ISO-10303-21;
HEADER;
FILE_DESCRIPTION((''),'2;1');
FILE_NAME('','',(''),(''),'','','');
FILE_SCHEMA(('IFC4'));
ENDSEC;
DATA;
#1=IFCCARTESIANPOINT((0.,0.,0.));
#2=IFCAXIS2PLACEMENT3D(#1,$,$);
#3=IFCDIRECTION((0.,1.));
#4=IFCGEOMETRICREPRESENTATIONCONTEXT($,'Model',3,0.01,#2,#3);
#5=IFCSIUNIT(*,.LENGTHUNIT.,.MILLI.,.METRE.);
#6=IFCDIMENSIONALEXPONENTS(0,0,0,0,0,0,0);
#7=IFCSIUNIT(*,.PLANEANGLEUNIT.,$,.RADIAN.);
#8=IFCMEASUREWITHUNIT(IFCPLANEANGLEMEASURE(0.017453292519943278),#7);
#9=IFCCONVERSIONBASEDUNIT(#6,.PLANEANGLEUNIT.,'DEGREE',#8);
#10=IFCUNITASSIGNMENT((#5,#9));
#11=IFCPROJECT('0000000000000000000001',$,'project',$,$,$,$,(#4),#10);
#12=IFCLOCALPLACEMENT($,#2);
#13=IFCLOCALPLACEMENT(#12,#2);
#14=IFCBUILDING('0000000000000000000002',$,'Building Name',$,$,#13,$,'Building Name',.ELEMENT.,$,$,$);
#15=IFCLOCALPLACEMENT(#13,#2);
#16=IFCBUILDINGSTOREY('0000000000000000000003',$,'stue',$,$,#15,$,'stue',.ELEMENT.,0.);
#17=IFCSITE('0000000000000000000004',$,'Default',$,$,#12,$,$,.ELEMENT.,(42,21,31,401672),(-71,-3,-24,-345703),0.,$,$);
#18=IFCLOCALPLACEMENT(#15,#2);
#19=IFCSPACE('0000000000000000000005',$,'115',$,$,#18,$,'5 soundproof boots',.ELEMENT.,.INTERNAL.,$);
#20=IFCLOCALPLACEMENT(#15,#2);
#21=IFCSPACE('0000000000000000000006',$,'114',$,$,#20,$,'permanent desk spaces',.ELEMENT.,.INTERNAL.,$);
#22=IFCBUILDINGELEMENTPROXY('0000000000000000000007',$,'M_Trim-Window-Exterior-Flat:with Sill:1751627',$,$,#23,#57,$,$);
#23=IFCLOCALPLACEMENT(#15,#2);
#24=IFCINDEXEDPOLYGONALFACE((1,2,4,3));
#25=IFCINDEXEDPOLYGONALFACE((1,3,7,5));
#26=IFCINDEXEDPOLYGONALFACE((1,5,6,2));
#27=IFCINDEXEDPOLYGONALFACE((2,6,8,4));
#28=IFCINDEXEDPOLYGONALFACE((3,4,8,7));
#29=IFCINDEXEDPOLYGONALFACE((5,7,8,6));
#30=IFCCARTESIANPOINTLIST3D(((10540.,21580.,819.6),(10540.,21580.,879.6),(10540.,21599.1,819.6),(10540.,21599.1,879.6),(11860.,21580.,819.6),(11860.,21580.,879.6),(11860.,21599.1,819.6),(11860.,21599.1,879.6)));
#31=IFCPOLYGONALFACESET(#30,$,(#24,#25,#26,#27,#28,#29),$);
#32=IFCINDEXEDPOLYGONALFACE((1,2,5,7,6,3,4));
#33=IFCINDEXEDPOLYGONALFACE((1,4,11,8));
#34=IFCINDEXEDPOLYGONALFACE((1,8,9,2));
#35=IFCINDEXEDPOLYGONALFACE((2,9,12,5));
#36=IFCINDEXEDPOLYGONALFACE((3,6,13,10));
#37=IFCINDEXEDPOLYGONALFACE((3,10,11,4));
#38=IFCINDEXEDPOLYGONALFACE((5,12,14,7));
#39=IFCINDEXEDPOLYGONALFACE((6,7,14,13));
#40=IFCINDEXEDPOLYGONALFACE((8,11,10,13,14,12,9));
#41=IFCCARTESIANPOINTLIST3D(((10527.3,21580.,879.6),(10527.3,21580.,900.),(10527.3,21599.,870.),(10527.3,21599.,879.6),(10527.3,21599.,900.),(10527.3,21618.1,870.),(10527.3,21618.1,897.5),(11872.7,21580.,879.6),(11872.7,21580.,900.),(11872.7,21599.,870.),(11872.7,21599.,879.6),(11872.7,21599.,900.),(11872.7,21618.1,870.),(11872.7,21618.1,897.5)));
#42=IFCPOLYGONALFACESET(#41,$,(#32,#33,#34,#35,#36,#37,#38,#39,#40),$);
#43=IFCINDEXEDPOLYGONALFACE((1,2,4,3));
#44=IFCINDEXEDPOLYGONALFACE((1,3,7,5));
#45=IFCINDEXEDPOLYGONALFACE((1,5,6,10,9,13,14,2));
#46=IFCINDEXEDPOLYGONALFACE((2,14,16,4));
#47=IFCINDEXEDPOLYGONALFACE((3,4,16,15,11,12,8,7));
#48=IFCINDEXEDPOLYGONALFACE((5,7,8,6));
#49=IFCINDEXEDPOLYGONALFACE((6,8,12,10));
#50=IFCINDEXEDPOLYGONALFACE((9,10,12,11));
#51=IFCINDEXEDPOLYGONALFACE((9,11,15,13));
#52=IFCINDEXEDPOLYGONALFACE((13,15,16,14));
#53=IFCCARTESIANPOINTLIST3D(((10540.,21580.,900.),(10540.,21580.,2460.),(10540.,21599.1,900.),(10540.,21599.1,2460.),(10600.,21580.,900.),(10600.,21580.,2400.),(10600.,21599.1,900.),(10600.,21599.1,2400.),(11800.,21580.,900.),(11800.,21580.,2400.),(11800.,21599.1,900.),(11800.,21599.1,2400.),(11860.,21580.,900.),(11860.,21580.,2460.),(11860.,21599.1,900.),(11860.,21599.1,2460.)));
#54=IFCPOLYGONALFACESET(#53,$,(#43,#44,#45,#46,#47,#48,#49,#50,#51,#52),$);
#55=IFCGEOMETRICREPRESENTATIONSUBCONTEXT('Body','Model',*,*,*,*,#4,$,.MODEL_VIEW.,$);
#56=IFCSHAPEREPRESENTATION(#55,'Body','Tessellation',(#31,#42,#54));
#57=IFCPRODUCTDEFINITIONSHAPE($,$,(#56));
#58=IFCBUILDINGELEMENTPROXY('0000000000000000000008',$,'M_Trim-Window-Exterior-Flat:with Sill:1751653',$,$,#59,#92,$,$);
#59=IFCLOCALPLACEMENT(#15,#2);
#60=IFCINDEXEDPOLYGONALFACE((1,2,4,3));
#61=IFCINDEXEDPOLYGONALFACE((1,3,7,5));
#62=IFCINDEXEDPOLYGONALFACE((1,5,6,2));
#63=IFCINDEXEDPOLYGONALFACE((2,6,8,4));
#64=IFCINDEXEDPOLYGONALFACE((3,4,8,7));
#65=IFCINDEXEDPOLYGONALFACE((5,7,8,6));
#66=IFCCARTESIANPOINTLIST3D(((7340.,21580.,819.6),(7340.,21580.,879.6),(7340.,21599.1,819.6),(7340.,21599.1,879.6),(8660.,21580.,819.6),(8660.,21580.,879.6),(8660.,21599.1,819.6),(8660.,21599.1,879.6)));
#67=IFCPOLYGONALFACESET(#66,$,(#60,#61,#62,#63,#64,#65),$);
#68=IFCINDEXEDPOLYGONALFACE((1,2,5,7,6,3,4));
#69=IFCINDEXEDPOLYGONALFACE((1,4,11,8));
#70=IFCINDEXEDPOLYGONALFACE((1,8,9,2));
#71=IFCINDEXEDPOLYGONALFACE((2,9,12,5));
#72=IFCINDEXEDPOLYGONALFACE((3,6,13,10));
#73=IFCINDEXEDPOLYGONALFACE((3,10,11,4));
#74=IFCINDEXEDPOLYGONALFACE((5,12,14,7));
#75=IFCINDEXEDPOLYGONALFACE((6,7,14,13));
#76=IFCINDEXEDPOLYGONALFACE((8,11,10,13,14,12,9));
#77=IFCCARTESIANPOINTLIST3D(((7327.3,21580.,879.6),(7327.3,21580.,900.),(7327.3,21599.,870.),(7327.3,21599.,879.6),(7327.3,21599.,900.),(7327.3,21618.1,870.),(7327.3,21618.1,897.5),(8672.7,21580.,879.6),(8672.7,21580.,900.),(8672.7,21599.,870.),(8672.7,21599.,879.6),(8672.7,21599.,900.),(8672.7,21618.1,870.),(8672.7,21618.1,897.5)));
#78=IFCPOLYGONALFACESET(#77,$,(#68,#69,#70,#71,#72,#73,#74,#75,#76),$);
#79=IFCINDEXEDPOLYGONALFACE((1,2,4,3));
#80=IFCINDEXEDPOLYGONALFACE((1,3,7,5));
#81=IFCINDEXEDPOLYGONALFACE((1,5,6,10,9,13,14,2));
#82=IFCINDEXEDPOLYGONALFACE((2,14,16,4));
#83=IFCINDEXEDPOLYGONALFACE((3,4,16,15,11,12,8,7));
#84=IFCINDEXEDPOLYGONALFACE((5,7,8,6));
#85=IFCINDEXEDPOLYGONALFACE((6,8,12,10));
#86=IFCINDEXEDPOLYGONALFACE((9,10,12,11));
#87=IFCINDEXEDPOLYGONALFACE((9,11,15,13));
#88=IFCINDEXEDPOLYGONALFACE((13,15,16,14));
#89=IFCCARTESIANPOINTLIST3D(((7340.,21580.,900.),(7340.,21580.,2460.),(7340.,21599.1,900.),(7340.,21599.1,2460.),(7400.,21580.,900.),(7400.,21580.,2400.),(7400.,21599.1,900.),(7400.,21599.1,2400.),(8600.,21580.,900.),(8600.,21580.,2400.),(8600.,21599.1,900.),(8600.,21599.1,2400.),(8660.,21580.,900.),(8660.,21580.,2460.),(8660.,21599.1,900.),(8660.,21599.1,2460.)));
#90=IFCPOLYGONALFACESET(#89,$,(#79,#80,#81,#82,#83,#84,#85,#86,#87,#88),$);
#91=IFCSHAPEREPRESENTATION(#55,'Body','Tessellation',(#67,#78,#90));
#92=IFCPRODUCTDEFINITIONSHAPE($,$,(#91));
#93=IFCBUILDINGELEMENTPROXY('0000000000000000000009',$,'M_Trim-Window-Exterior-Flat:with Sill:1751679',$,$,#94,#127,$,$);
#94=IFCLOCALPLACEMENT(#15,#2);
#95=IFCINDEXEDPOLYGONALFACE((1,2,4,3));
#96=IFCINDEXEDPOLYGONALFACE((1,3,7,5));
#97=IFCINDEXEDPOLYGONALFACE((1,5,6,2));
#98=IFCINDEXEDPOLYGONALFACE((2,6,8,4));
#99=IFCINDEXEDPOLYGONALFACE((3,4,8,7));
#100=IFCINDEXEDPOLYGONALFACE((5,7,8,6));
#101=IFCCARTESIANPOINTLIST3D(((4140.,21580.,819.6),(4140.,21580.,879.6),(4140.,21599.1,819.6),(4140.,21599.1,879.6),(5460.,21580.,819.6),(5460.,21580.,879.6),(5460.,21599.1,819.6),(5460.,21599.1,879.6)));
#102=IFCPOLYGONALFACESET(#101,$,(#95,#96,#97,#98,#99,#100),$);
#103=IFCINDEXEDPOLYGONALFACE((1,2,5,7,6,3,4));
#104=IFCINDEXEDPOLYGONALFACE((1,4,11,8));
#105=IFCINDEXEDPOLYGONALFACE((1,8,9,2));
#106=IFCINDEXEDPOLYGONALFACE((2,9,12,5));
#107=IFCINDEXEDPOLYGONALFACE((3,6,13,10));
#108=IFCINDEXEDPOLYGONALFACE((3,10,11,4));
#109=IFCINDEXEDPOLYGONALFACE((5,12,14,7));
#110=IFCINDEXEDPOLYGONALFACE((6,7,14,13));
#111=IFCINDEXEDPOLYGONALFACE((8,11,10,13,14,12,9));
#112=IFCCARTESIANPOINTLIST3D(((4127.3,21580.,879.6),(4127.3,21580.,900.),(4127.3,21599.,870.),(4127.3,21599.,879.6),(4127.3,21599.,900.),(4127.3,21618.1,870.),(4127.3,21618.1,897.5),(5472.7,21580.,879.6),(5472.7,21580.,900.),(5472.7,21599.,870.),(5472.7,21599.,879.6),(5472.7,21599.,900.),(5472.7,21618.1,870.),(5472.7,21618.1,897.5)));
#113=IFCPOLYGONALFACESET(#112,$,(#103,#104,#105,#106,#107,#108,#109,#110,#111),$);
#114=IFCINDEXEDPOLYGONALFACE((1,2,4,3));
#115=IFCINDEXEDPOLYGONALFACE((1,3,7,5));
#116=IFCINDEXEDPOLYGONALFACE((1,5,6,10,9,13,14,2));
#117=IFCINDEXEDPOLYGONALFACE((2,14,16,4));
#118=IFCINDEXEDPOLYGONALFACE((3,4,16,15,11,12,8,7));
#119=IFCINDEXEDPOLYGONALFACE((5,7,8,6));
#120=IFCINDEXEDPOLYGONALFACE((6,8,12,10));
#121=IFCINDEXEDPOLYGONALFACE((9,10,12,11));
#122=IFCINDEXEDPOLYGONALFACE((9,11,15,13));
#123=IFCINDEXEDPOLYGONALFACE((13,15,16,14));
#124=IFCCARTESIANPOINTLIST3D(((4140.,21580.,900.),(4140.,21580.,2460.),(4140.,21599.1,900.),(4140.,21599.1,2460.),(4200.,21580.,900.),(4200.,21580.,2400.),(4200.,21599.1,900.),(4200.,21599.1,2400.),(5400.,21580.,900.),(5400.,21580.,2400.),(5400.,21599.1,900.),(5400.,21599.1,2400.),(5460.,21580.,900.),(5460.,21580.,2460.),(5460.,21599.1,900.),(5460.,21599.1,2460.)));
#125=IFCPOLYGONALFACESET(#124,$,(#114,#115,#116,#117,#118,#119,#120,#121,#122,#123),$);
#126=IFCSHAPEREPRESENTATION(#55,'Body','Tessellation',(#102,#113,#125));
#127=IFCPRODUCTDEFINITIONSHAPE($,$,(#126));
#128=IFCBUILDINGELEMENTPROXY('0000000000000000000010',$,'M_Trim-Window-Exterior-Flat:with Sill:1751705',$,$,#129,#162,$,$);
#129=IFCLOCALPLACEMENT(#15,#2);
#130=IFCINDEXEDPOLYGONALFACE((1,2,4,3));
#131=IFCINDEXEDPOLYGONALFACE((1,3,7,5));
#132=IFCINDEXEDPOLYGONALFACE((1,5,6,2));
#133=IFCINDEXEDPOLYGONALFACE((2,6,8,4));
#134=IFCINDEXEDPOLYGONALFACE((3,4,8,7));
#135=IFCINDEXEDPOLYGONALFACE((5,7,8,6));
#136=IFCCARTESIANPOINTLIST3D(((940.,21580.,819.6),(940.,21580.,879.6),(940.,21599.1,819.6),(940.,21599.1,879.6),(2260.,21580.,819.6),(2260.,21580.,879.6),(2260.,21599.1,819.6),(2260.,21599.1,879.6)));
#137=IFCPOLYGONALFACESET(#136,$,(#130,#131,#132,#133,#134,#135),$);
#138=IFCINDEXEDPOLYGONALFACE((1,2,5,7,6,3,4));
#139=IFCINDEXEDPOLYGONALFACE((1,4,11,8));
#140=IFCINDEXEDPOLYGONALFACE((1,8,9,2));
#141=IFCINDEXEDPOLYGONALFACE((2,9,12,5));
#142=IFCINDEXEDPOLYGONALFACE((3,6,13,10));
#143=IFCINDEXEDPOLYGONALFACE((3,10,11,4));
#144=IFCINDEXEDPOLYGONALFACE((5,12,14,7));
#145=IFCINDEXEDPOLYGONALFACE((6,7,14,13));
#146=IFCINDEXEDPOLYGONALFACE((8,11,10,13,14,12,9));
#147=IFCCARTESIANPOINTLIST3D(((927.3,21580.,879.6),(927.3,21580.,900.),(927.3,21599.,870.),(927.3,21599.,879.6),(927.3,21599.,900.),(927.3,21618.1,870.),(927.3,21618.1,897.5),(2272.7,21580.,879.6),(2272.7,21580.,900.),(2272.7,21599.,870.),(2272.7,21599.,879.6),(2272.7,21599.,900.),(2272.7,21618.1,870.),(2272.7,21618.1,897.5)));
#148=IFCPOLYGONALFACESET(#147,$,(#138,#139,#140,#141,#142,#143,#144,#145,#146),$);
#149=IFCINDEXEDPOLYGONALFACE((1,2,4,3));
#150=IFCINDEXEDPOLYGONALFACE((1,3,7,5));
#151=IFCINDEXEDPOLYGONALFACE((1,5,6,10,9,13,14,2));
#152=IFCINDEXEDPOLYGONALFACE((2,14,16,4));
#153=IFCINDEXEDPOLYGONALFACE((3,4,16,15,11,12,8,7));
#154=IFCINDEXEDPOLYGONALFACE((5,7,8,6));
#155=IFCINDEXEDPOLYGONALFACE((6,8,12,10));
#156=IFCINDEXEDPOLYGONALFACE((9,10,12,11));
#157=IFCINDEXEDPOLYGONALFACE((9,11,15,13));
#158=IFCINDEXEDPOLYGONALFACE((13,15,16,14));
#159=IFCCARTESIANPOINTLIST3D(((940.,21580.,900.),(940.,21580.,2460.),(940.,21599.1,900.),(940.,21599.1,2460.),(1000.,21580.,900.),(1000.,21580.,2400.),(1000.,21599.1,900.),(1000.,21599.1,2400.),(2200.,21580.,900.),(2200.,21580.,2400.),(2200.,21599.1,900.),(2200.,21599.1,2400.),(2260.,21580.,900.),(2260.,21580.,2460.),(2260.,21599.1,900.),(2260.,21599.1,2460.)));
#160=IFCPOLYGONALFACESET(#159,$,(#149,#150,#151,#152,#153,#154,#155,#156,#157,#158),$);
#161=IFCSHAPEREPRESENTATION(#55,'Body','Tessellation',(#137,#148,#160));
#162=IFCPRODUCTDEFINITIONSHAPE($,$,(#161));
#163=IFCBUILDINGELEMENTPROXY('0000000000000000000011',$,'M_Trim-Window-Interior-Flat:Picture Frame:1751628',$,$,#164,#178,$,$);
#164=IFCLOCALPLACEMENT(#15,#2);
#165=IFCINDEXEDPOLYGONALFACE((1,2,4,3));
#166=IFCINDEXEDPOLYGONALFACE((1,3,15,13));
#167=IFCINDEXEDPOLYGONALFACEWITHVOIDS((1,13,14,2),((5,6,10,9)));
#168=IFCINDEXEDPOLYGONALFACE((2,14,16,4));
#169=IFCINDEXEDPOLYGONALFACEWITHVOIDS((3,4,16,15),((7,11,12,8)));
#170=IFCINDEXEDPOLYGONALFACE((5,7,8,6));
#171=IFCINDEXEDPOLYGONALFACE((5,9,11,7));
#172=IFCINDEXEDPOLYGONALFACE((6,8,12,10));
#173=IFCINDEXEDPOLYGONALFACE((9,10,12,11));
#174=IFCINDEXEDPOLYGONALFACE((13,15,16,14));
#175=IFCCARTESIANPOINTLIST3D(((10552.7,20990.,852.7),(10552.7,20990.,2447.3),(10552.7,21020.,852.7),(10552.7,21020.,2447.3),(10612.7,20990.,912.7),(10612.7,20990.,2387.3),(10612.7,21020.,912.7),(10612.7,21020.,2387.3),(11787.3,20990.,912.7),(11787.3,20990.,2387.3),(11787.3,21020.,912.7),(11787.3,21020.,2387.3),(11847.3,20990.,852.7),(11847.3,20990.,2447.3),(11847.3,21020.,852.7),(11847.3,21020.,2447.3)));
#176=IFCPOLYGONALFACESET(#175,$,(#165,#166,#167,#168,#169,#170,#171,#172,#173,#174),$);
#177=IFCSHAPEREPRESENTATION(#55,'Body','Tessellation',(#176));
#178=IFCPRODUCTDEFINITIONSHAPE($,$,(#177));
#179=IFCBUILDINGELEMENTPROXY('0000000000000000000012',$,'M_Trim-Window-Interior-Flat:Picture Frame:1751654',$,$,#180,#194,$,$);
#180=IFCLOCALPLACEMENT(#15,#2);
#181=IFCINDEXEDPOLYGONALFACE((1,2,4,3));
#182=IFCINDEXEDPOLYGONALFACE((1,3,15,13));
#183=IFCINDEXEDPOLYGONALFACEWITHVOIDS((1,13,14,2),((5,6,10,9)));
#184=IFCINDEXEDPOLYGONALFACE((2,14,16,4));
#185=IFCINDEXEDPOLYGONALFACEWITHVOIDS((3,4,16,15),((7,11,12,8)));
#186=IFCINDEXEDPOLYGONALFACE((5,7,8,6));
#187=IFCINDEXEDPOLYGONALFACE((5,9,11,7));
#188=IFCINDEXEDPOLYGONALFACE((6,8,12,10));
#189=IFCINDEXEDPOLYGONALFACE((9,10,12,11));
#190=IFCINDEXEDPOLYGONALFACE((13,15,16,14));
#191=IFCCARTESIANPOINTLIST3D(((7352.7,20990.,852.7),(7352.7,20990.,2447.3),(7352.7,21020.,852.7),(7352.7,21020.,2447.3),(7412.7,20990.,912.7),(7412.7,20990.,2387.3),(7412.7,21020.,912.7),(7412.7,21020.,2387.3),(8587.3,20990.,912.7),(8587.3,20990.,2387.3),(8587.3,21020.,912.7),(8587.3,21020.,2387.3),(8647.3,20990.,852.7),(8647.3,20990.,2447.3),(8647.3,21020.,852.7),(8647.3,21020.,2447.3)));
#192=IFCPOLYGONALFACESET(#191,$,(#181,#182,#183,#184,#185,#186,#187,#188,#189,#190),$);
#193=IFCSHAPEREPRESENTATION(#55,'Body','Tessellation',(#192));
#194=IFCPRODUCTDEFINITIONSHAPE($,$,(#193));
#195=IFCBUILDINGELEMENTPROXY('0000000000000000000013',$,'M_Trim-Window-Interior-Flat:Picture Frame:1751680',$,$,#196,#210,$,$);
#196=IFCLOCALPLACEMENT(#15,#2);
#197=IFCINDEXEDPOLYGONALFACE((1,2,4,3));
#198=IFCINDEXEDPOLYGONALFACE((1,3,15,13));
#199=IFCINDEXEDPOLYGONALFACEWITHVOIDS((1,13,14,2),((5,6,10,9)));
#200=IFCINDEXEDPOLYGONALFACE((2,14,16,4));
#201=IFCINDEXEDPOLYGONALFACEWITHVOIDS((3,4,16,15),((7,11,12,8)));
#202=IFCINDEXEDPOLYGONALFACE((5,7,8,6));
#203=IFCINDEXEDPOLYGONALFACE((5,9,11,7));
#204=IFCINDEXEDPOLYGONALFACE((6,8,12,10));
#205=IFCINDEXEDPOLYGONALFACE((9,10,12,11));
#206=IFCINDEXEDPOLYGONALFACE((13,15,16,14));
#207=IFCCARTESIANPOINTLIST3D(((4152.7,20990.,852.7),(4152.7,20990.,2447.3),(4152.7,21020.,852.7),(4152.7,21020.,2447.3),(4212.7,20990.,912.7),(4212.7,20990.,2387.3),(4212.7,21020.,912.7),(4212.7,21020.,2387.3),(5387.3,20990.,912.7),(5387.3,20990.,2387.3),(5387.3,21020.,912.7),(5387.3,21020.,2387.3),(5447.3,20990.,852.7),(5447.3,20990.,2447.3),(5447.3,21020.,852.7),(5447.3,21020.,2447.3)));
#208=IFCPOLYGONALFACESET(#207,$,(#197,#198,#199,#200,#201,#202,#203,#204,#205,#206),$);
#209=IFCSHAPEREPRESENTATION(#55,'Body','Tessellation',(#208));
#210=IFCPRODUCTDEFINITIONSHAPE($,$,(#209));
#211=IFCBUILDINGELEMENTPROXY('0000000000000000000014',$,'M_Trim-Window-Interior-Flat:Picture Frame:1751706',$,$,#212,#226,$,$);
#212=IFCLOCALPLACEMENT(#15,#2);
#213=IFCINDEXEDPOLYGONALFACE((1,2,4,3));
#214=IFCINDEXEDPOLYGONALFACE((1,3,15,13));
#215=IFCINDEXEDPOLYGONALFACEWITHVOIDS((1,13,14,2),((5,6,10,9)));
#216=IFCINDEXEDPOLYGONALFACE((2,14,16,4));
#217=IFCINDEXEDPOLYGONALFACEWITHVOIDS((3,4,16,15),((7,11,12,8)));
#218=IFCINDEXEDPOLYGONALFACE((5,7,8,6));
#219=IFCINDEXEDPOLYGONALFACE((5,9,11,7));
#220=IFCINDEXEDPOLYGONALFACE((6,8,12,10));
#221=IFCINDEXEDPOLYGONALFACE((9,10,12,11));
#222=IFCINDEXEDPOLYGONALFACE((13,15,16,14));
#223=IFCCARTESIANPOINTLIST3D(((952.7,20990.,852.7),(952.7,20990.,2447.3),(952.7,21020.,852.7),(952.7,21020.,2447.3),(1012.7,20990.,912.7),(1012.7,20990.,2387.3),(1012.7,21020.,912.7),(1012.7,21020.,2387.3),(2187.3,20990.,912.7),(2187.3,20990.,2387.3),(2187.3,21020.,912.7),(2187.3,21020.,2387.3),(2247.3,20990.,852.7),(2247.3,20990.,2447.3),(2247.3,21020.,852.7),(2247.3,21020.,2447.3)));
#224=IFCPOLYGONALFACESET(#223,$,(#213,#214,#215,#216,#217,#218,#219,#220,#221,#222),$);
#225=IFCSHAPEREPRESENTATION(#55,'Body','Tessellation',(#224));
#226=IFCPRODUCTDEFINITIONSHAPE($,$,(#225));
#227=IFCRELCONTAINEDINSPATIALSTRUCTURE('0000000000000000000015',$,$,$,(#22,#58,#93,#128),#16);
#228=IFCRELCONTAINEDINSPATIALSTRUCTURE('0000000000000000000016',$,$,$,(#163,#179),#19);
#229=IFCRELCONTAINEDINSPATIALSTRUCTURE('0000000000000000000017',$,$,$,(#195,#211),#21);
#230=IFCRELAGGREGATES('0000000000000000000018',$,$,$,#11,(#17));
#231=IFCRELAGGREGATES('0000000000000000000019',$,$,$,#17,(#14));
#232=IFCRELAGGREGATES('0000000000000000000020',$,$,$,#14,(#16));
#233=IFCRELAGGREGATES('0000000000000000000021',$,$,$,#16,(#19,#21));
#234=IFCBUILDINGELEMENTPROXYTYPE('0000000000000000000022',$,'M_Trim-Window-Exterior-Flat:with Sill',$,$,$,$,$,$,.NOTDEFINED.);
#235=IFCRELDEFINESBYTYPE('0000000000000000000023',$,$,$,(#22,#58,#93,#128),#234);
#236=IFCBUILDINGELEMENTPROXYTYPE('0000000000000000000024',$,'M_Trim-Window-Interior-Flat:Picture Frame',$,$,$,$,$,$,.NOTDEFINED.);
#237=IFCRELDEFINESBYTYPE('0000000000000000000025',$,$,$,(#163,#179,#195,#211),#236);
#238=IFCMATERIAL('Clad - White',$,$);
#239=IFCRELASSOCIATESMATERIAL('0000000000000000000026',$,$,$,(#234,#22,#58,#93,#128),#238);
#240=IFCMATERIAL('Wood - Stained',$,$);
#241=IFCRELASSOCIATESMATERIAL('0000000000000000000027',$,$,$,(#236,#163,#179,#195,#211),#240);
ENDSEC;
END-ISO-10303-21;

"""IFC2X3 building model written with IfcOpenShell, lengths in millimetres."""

from ifc_helpers import new_model, entity, si_unit, converted_unit, direction, frame, frame_2d, origin, place, context, subcontext, project, spatial, polyline, rectangle, outline, extrude, source, transform, mapped, material, type_object, type_shapes, element, save


model = new_model("IFC2X3")

# Units and contexts
model_context = context("Model", 3, precision=0.01, world=origin(), true_north=direction((0.0, 1.0)))
body_context = subcontext(model_context, "Body", "Model", "MODEL_VIEW")
ifc_project = project(units=[si_unit("LENGTHUNIT", "METRE", prefix="MILLI"), converted_unit("PLANEANGLEUNIT", "DEGREE", entity("IfcPlaneAngleMeasure", 0.017453292519943278), si_unit("PLANEANGLEUNIT", "RADIAN"), dimensions=[0, 0, 0, 0, 0, 0, 0])], contexts=[model_context])

# Site, building, storey
site_placement = place(None, origin())
site = spatial("IfcSite", under=ifc_project, at=site_placement, Name="Default", CompositionType="ELEMENT", RefLatitude=(42, 21, 31, 401672), RefLongitude=(-71, -3, -24, -345703), RefElevation=0.0)
building_placement = place(site_placement, origin())
building = spatial("IfcBuilding", under=site, at=building_placement, Name="Building Name", LongName="Building Name", CompositionType="ELEMENT")
storey_placement = place(building_placement, origin())
storey = spatial("IfcBuildingStorey", under=building, at=storey_placement, Name="stue", LongName="stue", CompositionType="ELEMENT", Elevation=0.0)

# Building element proxies
ifc_material_1 = material(Name="Clad - White")
ifc_material_2 = material(Name="Wood - Stained")
building_element_proxy_type_1 = type_object("IfcBuildingElementProxyType", Name="M_Trim-Window-Exterior-Flat:with Sill", PredefinedType="NOTDEFINED", material=ifc_material_1)
shared_shape_1 = source(origin(), body_context, "Body", "SweptSolid", [
    extrude(rectangle(XDim=1320.0, YDim=60.0, at=frame_2d((0.0, 0.0), x_axis=(1.0, 0.0))), frame((0.0, -1550.4, 0.0), z_axis=(0.0, 0.0, 1.0), x_axis=(-1.0, 0.0, 0.0)), (0.0, 0.0, 1.0), 19.0),
    extrude(outline(polyline([(-19.0, -15.2), (0.0, -15.2), (0.0, -5.7), (19.0, -5.7), (19.0, 14.8), (0.0, 14.8), (-19.0, 12.3), (-19.0, -15.2)])), frame((-672.7, -1514.8, 19.0), z_axis=(1.0, 0.0, 0.0), x_axis=(0.0, 0.0, -1.0)), (0.0, 0.0, 1.0), 1345.4),
    extrude(outline(polyline([(-795.0, -660.0), (765.0, -660.0), (765.0, -600.0), (-735.0, -600.0), (-735.0, 600.0), (765.0, 600.0), (765.0, 660.0), (-795.0, 660.0), (-795.0, -660.0)])), frame((0.0, -735.0, 0.0), z_axis=(0.0, 0.0, 1.0), x_axis=(0.0, -1.0, 0.0)), (0.0, 0.0, 1.0), 19.0),
])
type_shapes(building_element_proxy_type_1, [shared_shape_1])
for number, where, z_axis, x_axis, name in (
    (1, (11200.0, 21580.0, 2400.0), (0.0, 1.0, 0.0), (-1.0, 0.0, 0.0), "M_Trim-Window-Exterior-Flat:with Sill:1751627"),
    (2, (8000.0, 21580.0, 2400.0), (0.0, 1.0, 0.0), (-1.0, 0.0, 0.0), "M_Trim-Window-Exterior-Flat:with Sill:1751653"),
    (3, (4800.0, 21580.0, 2400.0), (0.0, 1.0, 0.0), (-1.0, 0.0, 0.0), "M_Trim-Window-Exterior-Flat:with Sill:1751679"),
    (4, (1600.0, 21580.0, 2400.0), (0.0, 1.0, 0.0), (-1.0, 0.0, 0.0), "M_Trim-Window-Exterior-Flat:with Sill:1751705"),
):
    element("IfcBuildingElementProxy", number, at=place(storey_placement, frame(where, z_axis=z_axis, x_axis=x_axis)), inside=storey, type_object=building_element_proxy_type_1, material=ifc_material_1, Name=name, context=body_context, shape_type="MappedRepresentation", body=[
        mapped(shared_shape_1, transform((0.0, 0.0, 0.0), scale=1.0)),
    ])

# Shared definitions
space_1_placement = place(storey_placement, origin())
space_1 = spatial("IfcSpace", under=storey, at=space_1_placement, Name="115", LongName="5 soundproof boots", CompositionType="ELEMENT", InteriorOrExteriorSpace="INTERNAL")

# Building element proxies
building_element_proxy_type_2 = type_object("IfcBuildingElementProxyType", Name="M_Trim-Window-Interior-Flat:Picture Frame", PredefinedType="NOTDEFINED", material=ifc_material_2)
shared_shape_2 = source(origin(), body_context, "Body", "SweptSolid", [
    extrude(outline(polyline([(-647.3, -797.3), (647.3, -797.3), (647.3, 797.3), (-647.3, 797.3), (-647.3, -797.3)]), holes=[polyline([(-587.3, -737.3), (-587.3, 737.3), (587.3, 737.3), (587.3, -737.3), (-587.3, -737.3)])]), frame((0.0, -750.0, 0.0), z_axis=(0.0, 0.0, 1.0), x_axis=(-1.0, 0.0, 0.0)), (0.0, 0.0, 1.0), 30.0),
])
type_shapes(building_element_proxy_type_2, [shared_shape_2])
for number, where, z_axis, x_axis, name in (
    (5, (11200.0, 21020.0, 2400.0), (0.0, -1.0, 0.0), (1.0, 0.0, 0.0), "M_Trim-Window-Interior-Flat:Picture Frame:1751628"),
    (6, (8000.0, 21020.0, 2400.0), (0.0, -1.0, 0.0), (1.0, 0.0, 0.0), "M_Trim-Window-Interior-Flat:Picture Frame:1751654"),
):
    element("IfcBuildingElementProxy", number, at=place(space_1_placement, frame(where, z_axis=z_axis, x_axis=x_axis)), inside=space_1, type_object=building_element_proxy_type_2, material=ifc_material_2, Name=name, context=body_context, shape_type="MappedRepresentation", body=[
        mapped(shared_shape_2, transform((0.0, 0.0, 0.0), scale=1.0)),
    ])

# Shared definitions
space_2_placement = place(storey_placement, origin())
space_2 = spatial("IfcSpace", under=storey, at=space_2_placement, Name="114", LongName="permanent desk spaces", CompositionType="ELEMENT", InteriorOrExteriorSpace="INTERNAL")

# Building element proxies
for number, where, z_axis, x_axis, name in (
    (7, (4800.0, 21020.0, 2400.0), (0.0, -1.0, 0.0), (1.0, 0.0, 0.0), "M_Trim-Window-Interior-Flat:Picture Frame:1751680"),
    (8, (1600.0, 21020.0, 2400.0), (0.0, -1.0, 0.0), (1.0, 0.0, 0.0), "M_Trim-Window-Interior-Flat:Picture Frame:1751706"),
):
    element("IfcBuildingElementProxy", number, at=place(space_2_placement, frame(where, z_axis=z_axis, x_axis=x_axis)), inside=space_2, type_object=building_element_proxy_type_2, material=ifc_material_2, Name=name, context=body_context, shape_type="MappedRepresentation", body=[
        mapped(shared_shape_2, transform((0.0, 0.0, 0.0), scale=1.0)),
    ])

save(model, "model.ifc")
